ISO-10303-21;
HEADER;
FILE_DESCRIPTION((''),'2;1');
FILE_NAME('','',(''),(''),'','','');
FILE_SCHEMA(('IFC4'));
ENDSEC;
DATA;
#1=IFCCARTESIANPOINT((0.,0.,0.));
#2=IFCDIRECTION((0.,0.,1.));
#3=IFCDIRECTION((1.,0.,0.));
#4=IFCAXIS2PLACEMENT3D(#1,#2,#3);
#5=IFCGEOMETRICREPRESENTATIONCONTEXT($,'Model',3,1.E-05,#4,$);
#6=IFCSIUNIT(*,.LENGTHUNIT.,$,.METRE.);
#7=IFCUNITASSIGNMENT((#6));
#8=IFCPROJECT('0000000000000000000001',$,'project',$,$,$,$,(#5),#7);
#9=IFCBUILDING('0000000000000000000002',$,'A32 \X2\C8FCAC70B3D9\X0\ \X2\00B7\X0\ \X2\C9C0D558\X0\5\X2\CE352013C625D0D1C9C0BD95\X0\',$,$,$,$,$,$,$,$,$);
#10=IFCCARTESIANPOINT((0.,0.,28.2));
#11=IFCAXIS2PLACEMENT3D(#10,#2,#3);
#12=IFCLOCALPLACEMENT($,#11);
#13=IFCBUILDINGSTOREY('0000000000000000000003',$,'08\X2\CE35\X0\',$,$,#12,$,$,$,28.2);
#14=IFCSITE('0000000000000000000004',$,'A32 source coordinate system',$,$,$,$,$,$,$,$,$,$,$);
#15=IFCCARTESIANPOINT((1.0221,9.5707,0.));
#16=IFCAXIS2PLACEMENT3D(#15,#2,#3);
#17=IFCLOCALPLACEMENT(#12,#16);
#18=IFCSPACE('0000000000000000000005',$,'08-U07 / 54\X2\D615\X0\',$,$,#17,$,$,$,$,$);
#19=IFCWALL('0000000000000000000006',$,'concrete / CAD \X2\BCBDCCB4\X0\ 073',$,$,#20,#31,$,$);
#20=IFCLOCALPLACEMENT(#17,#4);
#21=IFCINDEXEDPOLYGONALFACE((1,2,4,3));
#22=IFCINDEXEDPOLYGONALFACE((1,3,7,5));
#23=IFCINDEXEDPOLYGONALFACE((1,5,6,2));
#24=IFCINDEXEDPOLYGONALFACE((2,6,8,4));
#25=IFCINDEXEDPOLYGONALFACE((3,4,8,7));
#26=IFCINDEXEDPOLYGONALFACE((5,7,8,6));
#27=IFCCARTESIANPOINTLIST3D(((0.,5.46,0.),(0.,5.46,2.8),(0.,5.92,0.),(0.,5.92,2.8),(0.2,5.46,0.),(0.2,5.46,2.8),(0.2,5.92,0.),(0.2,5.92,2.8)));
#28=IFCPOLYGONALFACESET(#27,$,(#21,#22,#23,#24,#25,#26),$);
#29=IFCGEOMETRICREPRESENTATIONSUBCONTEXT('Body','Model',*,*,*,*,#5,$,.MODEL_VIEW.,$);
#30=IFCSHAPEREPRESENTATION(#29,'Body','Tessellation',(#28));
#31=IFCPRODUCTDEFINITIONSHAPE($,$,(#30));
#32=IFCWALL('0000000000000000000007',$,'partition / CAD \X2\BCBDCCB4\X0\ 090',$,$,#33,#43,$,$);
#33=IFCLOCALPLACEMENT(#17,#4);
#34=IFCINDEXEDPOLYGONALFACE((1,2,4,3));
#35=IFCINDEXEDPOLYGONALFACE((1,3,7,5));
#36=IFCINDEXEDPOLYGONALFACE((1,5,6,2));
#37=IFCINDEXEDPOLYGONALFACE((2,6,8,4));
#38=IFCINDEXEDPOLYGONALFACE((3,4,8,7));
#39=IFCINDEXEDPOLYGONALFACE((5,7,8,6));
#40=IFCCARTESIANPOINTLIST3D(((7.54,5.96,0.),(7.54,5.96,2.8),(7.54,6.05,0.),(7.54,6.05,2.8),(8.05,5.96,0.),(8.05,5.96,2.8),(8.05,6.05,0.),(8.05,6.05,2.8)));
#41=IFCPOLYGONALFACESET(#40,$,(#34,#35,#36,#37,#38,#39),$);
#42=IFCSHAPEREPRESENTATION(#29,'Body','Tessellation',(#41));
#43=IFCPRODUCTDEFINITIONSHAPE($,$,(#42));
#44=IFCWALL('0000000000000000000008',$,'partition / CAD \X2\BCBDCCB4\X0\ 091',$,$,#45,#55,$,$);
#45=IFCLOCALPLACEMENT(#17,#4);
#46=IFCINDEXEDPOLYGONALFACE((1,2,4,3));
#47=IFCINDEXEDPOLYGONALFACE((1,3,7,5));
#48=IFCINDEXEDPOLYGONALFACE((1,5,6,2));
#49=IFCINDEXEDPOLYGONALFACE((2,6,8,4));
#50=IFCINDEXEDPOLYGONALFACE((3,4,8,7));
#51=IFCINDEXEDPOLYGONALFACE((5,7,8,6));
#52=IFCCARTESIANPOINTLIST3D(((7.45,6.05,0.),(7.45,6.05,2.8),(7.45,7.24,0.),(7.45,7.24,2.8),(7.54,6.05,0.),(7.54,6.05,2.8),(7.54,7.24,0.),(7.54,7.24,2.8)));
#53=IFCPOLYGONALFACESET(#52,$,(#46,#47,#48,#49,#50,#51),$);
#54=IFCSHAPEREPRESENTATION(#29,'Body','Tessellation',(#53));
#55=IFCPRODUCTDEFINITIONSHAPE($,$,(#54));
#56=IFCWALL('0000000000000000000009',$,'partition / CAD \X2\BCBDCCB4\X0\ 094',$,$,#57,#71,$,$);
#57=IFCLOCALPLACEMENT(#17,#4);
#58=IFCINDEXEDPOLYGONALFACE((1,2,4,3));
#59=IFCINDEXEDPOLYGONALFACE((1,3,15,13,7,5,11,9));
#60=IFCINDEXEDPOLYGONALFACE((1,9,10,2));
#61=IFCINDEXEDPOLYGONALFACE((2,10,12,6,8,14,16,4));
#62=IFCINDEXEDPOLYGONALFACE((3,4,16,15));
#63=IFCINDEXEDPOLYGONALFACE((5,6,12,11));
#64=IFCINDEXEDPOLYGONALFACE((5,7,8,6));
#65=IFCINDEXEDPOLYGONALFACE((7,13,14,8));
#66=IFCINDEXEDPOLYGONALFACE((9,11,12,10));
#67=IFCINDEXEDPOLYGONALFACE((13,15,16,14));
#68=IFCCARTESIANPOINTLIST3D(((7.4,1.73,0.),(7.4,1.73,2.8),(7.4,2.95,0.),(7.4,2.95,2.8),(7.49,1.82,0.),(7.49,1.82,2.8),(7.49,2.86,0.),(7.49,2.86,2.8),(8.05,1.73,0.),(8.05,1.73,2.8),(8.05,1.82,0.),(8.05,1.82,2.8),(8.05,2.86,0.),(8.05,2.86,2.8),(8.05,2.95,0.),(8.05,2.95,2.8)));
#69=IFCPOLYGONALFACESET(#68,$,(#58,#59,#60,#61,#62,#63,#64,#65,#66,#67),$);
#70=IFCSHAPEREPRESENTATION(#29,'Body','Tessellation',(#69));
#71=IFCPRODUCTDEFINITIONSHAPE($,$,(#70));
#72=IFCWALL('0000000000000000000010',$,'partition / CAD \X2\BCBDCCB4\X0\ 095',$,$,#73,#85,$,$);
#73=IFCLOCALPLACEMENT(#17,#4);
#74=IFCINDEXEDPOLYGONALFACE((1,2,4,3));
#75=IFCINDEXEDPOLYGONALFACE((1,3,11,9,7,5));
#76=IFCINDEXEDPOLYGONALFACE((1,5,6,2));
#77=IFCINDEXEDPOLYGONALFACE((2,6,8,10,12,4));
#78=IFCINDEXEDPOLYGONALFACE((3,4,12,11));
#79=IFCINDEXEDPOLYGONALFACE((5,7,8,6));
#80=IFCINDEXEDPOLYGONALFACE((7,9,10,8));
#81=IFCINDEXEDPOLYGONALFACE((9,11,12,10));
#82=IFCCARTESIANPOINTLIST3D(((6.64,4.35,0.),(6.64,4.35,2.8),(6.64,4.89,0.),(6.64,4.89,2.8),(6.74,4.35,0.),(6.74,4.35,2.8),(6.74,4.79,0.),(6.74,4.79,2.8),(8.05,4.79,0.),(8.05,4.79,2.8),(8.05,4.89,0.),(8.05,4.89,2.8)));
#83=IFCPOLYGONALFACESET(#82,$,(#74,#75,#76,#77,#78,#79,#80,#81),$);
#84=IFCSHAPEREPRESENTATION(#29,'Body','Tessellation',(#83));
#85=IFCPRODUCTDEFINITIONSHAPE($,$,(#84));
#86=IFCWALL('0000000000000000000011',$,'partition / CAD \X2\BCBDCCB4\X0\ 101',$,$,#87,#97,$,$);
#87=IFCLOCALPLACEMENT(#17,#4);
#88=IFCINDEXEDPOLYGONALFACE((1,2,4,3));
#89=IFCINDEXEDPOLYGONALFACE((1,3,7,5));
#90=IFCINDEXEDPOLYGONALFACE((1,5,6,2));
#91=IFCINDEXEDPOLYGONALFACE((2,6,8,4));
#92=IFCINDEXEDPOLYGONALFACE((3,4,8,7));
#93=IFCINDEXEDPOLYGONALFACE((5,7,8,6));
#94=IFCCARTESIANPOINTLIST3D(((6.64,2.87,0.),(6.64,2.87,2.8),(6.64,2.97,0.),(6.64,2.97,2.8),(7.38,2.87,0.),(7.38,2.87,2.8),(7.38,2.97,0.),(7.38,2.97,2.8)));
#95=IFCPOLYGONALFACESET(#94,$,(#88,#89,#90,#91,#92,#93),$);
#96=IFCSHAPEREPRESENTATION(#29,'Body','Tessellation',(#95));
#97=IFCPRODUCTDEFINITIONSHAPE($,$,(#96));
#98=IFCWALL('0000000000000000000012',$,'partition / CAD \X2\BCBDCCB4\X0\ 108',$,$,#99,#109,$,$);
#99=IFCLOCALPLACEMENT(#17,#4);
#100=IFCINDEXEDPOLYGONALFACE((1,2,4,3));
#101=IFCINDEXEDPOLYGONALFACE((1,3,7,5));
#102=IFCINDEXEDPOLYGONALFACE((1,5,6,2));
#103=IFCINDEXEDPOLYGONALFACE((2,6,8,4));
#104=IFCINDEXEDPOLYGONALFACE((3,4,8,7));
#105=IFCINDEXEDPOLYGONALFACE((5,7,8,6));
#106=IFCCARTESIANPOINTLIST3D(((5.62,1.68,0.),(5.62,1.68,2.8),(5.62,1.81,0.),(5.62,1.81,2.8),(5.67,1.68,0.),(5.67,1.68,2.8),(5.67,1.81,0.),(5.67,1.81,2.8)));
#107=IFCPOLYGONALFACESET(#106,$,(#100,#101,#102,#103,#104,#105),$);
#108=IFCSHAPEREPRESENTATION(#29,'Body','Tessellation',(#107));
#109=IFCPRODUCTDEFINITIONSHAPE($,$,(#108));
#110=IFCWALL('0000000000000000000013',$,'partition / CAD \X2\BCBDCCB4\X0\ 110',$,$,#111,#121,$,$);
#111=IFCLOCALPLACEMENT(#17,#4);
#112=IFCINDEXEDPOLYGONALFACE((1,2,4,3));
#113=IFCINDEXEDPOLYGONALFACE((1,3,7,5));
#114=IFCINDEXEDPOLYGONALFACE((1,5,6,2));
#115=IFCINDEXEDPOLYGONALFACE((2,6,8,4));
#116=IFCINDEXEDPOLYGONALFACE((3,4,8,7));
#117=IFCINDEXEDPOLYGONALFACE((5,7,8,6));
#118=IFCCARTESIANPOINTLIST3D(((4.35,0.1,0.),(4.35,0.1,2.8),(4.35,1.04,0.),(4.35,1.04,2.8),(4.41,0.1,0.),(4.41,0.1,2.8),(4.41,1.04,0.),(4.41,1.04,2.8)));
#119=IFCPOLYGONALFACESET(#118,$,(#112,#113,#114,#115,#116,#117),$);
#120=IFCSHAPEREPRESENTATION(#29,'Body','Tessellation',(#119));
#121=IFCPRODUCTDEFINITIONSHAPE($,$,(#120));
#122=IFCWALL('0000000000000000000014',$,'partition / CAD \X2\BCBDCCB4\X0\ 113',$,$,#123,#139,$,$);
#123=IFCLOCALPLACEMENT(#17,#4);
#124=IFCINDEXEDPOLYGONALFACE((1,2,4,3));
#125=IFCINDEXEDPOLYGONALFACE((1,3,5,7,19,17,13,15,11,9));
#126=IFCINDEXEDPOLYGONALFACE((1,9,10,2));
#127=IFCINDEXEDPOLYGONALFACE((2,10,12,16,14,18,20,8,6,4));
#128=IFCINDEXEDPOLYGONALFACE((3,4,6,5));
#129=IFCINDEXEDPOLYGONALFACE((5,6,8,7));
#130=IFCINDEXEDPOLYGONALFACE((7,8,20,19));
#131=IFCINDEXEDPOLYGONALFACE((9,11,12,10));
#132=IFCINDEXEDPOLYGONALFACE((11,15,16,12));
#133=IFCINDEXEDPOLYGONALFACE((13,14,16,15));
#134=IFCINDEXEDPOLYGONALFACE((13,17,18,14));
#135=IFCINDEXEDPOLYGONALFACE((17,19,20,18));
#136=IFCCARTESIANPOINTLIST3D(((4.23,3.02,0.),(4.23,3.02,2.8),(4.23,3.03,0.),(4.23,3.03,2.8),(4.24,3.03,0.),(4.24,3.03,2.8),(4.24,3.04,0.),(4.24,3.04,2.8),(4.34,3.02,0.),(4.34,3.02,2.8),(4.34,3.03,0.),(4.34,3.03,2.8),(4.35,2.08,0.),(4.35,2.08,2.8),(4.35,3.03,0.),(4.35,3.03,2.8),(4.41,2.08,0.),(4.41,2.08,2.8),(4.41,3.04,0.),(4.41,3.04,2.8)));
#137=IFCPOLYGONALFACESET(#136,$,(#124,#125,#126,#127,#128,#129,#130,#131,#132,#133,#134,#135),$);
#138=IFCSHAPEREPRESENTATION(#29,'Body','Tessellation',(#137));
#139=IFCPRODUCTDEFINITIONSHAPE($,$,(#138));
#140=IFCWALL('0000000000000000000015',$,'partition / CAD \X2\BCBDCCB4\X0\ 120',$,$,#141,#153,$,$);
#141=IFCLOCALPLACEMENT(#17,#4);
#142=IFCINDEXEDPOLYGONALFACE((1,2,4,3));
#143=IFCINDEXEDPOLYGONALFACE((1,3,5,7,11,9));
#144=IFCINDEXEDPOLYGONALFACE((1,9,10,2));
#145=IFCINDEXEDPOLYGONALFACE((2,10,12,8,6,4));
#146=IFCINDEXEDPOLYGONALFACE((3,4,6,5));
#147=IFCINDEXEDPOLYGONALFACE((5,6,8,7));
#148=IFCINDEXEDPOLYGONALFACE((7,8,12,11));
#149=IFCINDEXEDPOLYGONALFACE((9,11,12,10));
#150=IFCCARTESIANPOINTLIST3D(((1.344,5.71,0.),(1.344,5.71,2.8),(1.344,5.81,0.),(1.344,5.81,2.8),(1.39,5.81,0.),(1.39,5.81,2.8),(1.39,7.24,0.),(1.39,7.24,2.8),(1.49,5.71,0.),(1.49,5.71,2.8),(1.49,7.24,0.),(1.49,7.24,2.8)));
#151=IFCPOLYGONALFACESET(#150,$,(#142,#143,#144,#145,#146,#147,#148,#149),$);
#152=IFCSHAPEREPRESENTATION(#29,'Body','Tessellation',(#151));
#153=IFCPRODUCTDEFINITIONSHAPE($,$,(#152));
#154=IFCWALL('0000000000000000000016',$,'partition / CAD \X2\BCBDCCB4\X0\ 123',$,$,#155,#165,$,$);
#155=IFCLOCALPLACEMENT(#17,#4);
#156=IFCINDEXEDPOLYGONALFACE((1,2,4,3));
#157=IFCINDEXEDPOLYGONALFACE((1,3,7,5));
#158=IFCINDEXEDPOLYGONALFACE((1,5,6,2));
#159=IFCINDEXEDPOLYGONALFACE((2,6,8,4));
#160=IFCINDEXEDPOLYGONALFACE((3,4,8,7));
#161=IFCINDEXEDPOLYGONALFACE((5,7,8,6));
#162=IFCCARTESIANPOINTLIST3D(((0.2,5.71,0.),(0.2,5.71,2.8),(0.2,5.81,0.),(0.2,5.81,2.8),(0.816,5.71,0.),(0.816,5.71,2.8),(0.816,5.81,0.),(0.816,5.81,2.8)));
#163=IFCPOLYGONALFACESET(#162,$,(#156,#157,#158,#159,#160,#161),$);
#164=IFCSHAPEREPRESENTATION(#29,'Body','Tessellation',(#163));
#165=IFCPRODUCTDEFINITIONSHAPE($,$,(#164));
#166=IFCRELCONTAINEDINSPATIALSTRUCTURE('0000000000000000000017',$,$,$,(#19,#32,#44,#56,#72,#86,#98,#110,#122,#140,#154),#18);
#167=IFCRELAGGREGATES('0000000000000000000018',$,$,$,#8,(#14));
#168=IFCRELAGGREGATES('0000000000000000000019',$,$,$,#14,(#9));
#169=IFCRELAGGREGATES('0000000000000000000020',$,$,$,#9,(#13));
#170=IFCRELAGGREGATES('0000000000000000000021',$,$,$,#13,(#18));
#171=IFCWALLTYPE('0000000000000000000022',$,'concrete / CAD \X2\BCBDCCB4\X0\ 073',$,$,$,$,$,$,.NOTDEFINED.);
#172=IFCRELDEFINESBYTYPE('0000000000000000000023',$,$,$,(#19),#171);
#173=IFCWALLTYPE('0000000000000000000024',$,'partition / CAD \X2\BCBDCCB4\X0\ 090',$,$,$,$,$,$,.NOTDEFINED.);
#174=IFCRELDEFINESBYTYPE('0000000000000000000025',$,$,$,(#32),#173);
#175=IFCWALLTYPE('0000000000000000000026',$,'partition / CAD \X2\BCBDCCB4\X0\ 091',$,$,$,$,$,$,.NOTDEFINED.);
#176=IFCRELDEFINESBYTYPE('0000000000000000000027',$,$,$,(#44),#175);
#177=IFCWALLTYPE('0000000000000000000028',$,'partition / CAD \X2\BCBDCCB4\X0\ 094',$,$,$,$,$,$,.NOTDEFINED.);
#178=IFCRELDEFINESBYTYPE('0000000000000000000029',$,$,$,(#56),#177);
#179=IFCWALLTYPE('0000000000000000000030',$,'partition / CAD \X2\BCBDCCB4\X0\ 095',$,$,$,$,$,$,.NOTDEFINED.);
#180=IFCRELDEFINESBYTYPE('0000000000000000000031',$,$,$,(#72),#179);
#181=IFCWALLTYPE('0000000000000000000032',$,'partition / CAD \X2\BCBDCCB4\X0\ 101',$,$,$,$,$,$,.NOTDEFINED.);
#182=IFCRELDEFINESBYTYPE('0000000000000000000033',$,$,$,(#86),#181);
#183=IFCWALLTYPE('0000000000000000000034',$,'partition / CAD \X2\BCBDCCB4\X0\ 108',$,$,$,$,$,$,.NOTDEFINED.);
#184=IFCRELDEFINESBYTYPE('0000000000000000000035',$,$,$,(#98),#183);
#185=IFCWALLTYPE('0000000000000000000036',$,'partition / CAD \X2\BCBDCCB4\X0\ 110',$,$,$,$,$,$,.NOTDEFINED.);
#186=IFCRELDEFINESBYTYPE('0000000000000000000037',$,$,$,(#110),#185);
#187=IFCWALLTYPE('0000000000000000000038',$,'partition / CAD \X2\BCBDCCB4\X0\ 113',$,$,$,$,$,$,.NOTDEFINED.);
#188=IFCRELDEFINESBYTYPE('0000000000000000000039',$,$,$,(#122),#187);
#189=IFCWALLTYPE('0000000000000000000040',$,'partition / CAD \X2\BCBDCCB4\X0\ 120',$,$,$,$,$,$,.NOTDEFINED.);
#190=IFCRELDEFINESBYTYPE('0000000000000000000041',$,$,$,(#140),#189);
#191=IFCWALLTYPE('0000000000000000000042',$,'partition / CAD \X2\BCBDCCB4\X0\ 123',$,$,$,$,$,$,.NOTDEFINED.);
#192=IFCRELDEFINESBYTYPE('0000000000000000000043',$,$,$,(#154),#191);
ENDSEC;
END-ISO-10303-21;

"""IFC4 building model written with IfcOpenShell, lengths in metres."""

from ifc_helpers import new_model, si_unit, frame, origin, origin_with_axes, place, context, subcontext, project, spatial, polyline, outline, extrude, source, transform, mapped, type_object, type_shapes, element, save


model = new_model("IFC4")

# Units and contexts
model_context = context("Model", 3, precision=1e-05, world=origin_with_axes())
body_context = subcontext(model_context, "Body", "Model", "MODEL_VIEW")
ifc_project = project(units=[si_unit("LENGTHUNIT", "METRE")], contexts=[model_context])

# Site, building, storey, space
site = spatial("IfcSite", under=ifc_project, Name="A32 source coordinate system")
building = spatial("IfcBuilding", under=site, Name="A32 주거동 · 지하5층–옥탑지붕")
storey_placement = place(None, frame((0.0, 0.0, 28.2), z_axis=(0.0, 0.0, 1.0), x_axis=(1.0, 0.0, 0.0)))
storey = spatial("IfcBuildingStorey", under=building, at=storey_placement, Name="08층", Elevation=28.2)
space_1_placement = place(storey_placement, frame((1.0221, 9.5707, 0.0), z_axis=(0.0, 0.0, 1.0), x_axis=(1.0, 0.0, 0.0)))
space_1 = spatial("IfcSpace", under=storey, at=space_1_placement, Name="08-U07 / 54형")

# Walls
wall_type_1 = type_object("IfcWallType", Name="concrete / CAD 벽체 073", PredefinedType="NOTDEFINED")
shared_shape_1 = source(origin(), body_context, "Body", "SweptSolid", [
    extrude(outline(polyline([(0.2, 5.92), (0.2, 5.46), (0.0, 5.46), (0.0, 5.92), (0.2, 5.92)])), origin(), (0.0, 0.0, 1.0), 2.8),
])
type_shapes(wall_type_1, [shared_shape_1])
wall_1_placement = place(space_1_placement, origin_with_axes())
element("IfcWall", 1, at=wall_1_placement, inside=space_1, type_object=wall_type_1, Name="concrete / CAD 벽체 073", context=body_context, shape_type="MappedRepresentation", body=[
    mapped(shared_shape_1, transform((0.0, 0.0, 0.0), scale=1.0)),
])
wall_type_2 = type_object("IfcWallType", Name="partition / CAD 벽체 090", PredefinedType="NOTDEFINED")
shared_shape_2 = source(origin(), body_context, "Body", "SweptSolid", [
    extrude(outline(polyline([(7.54, 5.96), (7.54, 6.05), (8.05, 6.05), (8.05, 5.96), (7.54, 5.96)])), origin(), (0.0, 0.0, 1.0), 2.8),
])
type_shapes(wall_type_2, [shared_shape_2])
wall_2_placement = place(space_1_placement, origin_with_axes())
element("IfcWall", 2, at=wall_2_placement, inside=space_1, type_object=wall_type_2, Name="partition / CAD 벽체 090", context=body_context, shape_type="MappedRepresentation", body=[
    mapped(shared_shape_2, transform((0.0, 0.0, 0.0), scale=1.0)),
])
wall_type_3 = type_object("IfcWallType", Name="partition / CAD 벽체 091", PredefinedType="NOTDEFINED")
shared_shape_3 = source(origin(), body_context, "Body", "SweptSolid", [
    extrude(outline(polyline([(7.54, 6.05), (7.45, 6.05), (7.45, 7.24), (7.54, 7.24), (7.54, 6.05)])), origin(), (0.0, 0.0, 1.0), 2.8),
])
type_shapes(wall_type_3, [shared_shape_3])
wall_3_placement = place(space_1_placement, origin_with_axes())
element("IfcWall", 3, at=wall_3_placement, inside=space_1, type_object=wall_type_3, Name="partition / CAD 벽체 091", context=body_context, shape_type="MappedRepresentation", body=[
    mapped(shared_shape_3, transform((0.0, 0.0, 0.0), scale=1.0)),
])
wall_type_4 = type_object("IfcWallType", Name="partition / CAD 벽체 094", PredefinedType="NOTDEFINED")
shared_shape_4 = source(origin(), body_context, "Body", "SweptSolid", [
    extrude(outline(polyline([(8.05, 1.73), (7.4, 1.73), (7.4, 2.95), (8.05, 2.95), (8.05, 2.86), (7.49, 2.86), (7.49, 1.82), (8.05, 1.82), (8.05, 1.73)])), origin(), (0.0, 0.0, 1.0), 2.8),
])
type_shapes(wall_type_4, [shared_shape_4])
wall_4_placement = place(space_1_placement, origin_with_axes())
element("IfcWall", 4, at=wall_4_placement, inside=space_1, type_object=wall_type_4, Name="partition / CAD 벽체 094", context=body_context, shape_type="MappedRepresentation", body=[
    mapped(shared_shape_4, transform((0.0, 0.0, 0.0), scale=1.0)),
])
wall_type_5 = type_object("IfcWallType", Name="partition / CAD 벽체 095", PredefinedType="NOTDEFINED")
shared_shape_5 = source(origin(), body_context, "Body", "SweptSolid", [
    extrude(outline(polyline([(6.64, 4.89), (8.05, 4.89), (8.05, 4.79), (6.74, 4.79), (6.74, 4.35), (6.64, 4.35), (6.64, 4.89)])), origin(), (0.0, 0.0, 1.0), 2.8),
])
type_shapes(wall_type_5, [shared_shape_5])
wall_5_placement = place(space_1_placement, origin_with_axes())
element("IfcWall", 5, at=wall_5_placement, inside=space_1, type_object=wall_type_5, Name="partition / CAD 벽체 095", context=body_context, shape_type="MappedRepresentation", body=[
    mapped(shared_shape_5, transform((0.0, 0.0, 0.0), scale=1.0)),
])
wall_type_6 = type_object("IfcWallType", Name="partition / CAD 벽체 101", PredefinedType="NOTDEFINED")
shared_shape_6 = source(origin(), body_context, "Body", "SweptSolid", [
    extrude(outline(polyline([(7.38, 2.97), (7.38, 2.87), (6.64, 2.87), (6.64, 2.97), (7.38, 2.97)])), origin(), (0.0, 0.0, 1.0), 2.8),
])
type_shapes(wall_type_6, [shared_shape_6])
wall_6_placement = place(space_1_placement, origin_with_axes())
element("IfcWall", 6, at=wall_6_placement, inside=space_1, type_object=wall_type_6, Name="partition / CAD 벽체 101", context=body_context, shape_type="MappedRepresentation", body=[
    mapped(shared_shape_6, transform((0.0, 0.0, 0.0), scale=1.0)),
])
wall_type_7 = type_object("IfcWallType", Name="partition / CAD 벽체 108", PredefinedType="NOTDEFINED")
shared_shape_7 = source(origin(), body_context, "Body", "SweptSolid", [
    extrude(outline(polyline([(5.67, 1.68), (5.62, 1.68), (5.62, 1.81), (5.67, 1.81), (5.67, 1.68)])), origin(), (0.0, 0.0, 1.0), 2.8),
])
type_shapes(wall_type_7, [shared_shape_7])
wall_7_placement = place(space_1_placement, origin_with_axes())
element("IfcWall", 7, at=wall_7_placement, inside=space_1, type_object=wall_type_7, Name="partition / CAD 벽체 108", context=body_context, shape_type="MappedRepresentation", body=[
    mapped(shared_shape_7, transform((0.0, 0.0, 0.0), scale=1.0)),
])
wall_type_8 = type_object("IfcWallType", Name="partition / CAD 벽체 110", PredefinedType="NOTDEFINED")
shared_shape_8 = source(origin(), body_context, "Body", "SweptSolid", [
    extrude(outline(polyline([(4.35, 1.04), (4.41, 1.04), (4.41, 0.1), (4.35, 0.1), (4.35, 1.04)])), origin(), (0.0, 0.0, 1.0), 2.8),
])
type_shapes(wall_type_8, [shared_shape_8])
wall_8_placement = place(space_1_placement, origin_with_axes())
element("IfcWall", 8, at=wall_8_placement, inside=space_1, type_object=wall_type_8, Name="partition / CAD 벽체 110", context=body_context, shape_type="MappedRepresentation", body=[
    mapped(shared_shape_8, transform((0.0, 0.0, 0.0), scale=1.0)),
])
wall_type_9 = type_object("IfcWallType", Name="partition / CAD 벽체 113", PredefinedType="NOTDEFINED")
shared_shape_9 = source(origin(), body_context, "Body", "SweptSolid", [
    extrude(outline(polyline([(4.24, 3.04), (4.41, 3.04), (4.41, 2.08), (4.35, 2.08), (4.35, 3.03), (4.34, 3.03), (4.34, 3.02), (4.23, 3.02), (4.23, 3.03), (4.24, 3.03), (4.24, 3.04)])), origin(), (0.0, 0.0, 1.0), 2.8),
])
type_shapes(wall_type_9, [shared_shape_9])
wall_9_placement = place(space_1_placement, origin_with_axes())
element("IfcWall", 9, at=wall_9_placement, inside=space_1, type_object=wall_type_9, Name="partition / CAD 벽체 113", context=body_context, shape_type="MappedRepresentation", body=[
    mapped(shared_shape_9, transform((0.0, 0.0, 0.0), scale=1.0)),
])
wall_type_10 = type_object("IfcWallType", Name="partition / CAD 벽체 120", PredefinedType="NOTDEFINED")
shared_shape_10 = source(origin(), body_context, "Body", "SweptSolid", [
    extrude(outline(polyline([(1.39, 7.24), (1.49, 7.24), (1.49, 5.71), (1.344, 5.71), (1.344, 5.81), (1.39, 5.81), (1.39, 7.24)])), origin(), (0.0, 0.0, 1.0), 2.8),
])
type_shapes(wall_type_10, [shared_shape_10])
wall_10_placement = place(space_1_placement, origin_with_axes())
element("IfcWall", 10, at=wall_10_placement, inside=space_1, type_object=wall_type_10, Name="partition / CAD 벽체 120", context=body_context, shape_type="MappedRepresentation", body=[
    mapped(shared_shape_10, transform((0.0, 0.0, 0.0), scale=1.0)),
])
wall_type_11 = type_object("IfcWallType", Name="partition / CAD 벽체 123", PredefinedType="NOTDEFINED")
shared_shape_11 = source(origin(), body_context, "Body", "SweptSolid", [
    extrude(outline(polyline([(0.816, 5.81), (0.816, 5.71), (0.2, 5.71), (0.2, 5.81), (0.816, 5.81)])), origin(), (0.0, 0.0, 1.0), 2.8),
])
type_shapes(wall_type_11, [shared_shape_11])
wall_11_placement = place(space_1_placement, origin_with_axes())
element("IfcWall", 11, at=wall_11_placement, inside=space_1, type_object=wall_type_11, Name="partition / CAD 벽체 123", context=body_context, shape_type="MappedRepresentation", body=[
    mapped(shared_shape_11, transform((0.0, 0.0, 0.0), scale=1.0)),
])

save(model, "model.ifc")
